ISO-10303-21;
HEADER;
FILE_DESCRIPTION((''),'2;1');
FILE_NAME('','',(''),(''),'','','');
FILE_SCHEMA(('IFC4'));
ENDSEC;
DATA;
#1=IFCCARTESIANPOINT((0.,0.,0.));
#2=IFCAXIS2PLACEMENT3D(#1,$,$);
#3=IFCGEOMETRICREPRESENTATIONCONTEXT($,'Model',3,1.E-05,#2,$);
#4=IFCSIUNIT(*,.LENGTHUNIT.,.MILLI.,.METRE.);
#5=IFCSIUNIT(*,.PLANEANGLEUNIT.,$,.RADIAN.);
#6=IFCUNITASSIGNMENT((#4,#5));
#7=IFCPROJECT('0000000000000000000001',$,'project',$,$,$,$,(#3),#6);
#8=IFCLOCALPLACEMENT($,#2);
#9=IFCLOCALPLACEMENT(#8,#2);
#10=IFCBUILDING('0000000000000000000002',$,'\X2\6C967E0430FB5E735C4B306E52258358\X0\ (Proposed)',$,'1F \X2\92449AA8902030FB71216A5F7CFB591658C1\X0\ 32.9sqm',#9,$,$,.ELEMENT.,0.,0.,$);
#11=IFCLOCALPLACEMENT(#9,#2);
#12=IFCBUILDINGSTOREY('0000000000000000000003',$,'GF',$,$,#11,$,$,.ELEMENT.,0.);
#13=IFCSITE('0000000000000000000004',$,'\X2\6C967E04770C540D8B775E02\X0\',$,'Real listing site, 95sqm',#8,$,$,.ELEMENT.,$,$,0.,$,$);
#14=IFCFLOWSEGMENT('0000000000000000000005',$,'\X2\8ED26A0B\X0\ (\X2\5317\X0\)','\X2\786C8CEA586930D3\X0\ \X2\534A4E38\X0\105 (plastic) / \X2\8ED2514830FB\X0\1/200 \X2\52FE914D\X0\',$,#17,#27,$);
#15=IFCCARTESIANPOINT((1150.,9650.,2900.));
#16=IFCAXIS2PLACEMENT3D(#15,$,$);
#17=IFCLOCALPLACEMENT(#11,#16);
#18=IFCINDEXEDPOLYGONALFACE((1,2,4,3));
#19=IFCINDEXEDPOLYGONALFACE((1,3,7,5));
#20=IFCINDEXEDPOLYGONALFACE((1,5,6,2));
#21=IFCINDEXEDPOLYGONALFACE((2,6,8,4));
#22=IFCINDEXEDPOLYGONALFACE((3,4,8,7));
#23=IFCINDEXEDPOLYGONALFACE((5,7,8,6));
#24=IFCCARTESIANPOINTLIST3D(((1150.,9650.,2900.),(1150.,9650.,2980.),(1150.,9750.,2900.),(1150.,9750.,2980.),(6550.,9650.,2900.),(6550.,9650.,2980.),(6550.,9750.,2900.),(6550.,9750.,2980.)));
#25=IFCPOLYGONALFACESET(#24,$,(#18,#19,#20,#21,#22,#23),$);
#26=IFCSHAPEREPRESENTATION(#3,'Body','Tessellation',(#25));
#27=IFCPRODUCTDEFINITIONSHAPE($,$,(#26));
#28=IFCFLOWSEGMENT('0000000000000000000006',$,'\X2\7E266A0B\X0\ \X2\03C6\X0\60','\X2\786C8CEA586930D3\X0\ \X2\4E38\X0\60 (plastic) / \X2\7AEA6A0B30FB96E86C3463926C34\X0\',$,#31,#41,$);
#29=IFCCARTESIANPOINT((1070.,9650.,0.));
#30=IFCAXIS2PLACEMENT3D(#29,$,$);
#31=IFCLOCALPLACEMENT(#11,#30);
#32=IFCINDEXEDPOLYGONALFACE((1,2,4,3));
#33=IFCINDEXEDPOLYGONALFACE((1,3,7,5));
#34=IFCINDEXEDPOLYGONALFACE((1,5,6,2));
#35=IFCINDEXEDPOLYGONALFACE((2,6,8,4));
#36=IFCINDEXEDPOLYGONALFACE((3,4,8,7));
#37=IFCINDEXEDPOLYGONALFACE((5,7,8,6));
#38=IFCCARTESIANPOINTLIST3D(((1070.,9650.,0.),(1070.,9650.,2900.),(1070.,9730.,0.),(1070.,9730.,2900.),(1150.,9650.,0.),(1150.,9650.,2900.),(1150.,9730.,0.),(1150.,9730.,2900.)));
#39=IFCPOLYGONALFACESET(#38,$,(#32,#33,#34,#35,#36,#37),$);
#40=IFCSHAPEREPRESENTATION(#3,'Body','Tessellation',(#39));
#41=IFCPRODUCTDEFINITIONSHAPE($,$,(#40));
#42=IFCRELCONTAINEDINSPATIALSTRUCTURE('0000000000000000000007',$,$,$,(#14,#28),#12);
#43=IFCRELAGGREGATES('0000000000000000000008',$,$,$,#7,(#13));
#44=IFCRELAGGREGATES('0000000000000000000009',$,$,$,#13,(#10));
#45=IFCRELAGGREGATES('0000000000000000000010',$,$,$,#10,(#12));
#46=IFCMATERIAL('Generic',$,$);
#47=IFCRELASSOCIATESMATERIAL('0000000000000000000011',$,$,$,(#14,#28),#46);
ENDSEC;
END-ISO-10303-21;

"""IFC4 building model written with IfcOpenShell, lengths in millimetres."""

from ifc_helpers import new_model, si_unit, frame, frame_2d, origin, place, context, project, spatial, rectangle, extrude, material, element, save


model = new_model("IFC4")

# Units and contexts
model_context = context("Model", 3, precision=1e-05, world=origin())
ifc_project = project(units=[si_unit("LENGTHUNIT", "METRE", prefix="MILLI"), si_unit("PLANEANGLEUNIT", "RADIAN")], contexts=[model_context])

# Site, building, storey
site_placement = place(None, origin())
site = spatial("IfcSite", under=ifc_project, at=site_placement, Name="沖縄県名護市", ObjectType="Real listing site, 95sqm", CompositionType="ELEMENT", RefElevation=0.0)
building_placement = place(site_placement, origin())
building = spatial("IfcBuilding", under=site, at=building_placement, Name="沖縄・平屋の別荘 (Proposed)", ObjectType="1F 鉄骨造・無機系外壁 32.9sqm", CompositionType="ELEMENT", ElevationOfRefHeight=0.0, ElevationOfTerrain=0.0)
storey_placement = place(building_placement, origin())
storey = spatial("IfcBuildingStorey", under=building, at=storey_placement, Name="GF", CompositionType="ELEMENT", Elevation=0.0)

# Shared definitions
ifc_material_1 = material(Name="Generic")

# Flow segments
flow_segment_1_placement = place(storey_placement, frame((1150.0, 9650.0, 2900.0)))
element("IfcFlowSegment", 1, at=flow_segment_1_placement, inside=storey, material=ifc_material_1, Name="軒樋 (北)", Description="硬質塩ビ 半丸105 (plastic) / 軒先・1/200 勾配", context=model_context, shape_type="SweptSolid", body=[
    extrude(rectangle(XDim=5400.0, YDim=100.0, at=frame_2d((2700.0, 50.0))), frame((1150.0, 9650.0, 2900.0)), (0.0, 0.0, 1.0), 80.0),
])
flow_segment_2_placement = place(storey_placement, frame((1070.0, 9650.0, 0.0)))
element("IfcFlowSegment", 2, at=flow_segment_2_placement, inside=storey, material=ifc_material_1, Name="縦樋 φ60", Description="硬質塩ビ 丸60 (plastic) / 竪樋・雨水排水", context=model_context, shape_type="SweptSolid", body=[
    extrude(rectangle(XDim=80.0, YDim=80.0, at=frame_2d((40.0, 40.0))), frame((1070.0, 9650.0, 0.0)), (0.0, 0.0, 1.0), 2900.0),
])

save(model, "model.ifc")
